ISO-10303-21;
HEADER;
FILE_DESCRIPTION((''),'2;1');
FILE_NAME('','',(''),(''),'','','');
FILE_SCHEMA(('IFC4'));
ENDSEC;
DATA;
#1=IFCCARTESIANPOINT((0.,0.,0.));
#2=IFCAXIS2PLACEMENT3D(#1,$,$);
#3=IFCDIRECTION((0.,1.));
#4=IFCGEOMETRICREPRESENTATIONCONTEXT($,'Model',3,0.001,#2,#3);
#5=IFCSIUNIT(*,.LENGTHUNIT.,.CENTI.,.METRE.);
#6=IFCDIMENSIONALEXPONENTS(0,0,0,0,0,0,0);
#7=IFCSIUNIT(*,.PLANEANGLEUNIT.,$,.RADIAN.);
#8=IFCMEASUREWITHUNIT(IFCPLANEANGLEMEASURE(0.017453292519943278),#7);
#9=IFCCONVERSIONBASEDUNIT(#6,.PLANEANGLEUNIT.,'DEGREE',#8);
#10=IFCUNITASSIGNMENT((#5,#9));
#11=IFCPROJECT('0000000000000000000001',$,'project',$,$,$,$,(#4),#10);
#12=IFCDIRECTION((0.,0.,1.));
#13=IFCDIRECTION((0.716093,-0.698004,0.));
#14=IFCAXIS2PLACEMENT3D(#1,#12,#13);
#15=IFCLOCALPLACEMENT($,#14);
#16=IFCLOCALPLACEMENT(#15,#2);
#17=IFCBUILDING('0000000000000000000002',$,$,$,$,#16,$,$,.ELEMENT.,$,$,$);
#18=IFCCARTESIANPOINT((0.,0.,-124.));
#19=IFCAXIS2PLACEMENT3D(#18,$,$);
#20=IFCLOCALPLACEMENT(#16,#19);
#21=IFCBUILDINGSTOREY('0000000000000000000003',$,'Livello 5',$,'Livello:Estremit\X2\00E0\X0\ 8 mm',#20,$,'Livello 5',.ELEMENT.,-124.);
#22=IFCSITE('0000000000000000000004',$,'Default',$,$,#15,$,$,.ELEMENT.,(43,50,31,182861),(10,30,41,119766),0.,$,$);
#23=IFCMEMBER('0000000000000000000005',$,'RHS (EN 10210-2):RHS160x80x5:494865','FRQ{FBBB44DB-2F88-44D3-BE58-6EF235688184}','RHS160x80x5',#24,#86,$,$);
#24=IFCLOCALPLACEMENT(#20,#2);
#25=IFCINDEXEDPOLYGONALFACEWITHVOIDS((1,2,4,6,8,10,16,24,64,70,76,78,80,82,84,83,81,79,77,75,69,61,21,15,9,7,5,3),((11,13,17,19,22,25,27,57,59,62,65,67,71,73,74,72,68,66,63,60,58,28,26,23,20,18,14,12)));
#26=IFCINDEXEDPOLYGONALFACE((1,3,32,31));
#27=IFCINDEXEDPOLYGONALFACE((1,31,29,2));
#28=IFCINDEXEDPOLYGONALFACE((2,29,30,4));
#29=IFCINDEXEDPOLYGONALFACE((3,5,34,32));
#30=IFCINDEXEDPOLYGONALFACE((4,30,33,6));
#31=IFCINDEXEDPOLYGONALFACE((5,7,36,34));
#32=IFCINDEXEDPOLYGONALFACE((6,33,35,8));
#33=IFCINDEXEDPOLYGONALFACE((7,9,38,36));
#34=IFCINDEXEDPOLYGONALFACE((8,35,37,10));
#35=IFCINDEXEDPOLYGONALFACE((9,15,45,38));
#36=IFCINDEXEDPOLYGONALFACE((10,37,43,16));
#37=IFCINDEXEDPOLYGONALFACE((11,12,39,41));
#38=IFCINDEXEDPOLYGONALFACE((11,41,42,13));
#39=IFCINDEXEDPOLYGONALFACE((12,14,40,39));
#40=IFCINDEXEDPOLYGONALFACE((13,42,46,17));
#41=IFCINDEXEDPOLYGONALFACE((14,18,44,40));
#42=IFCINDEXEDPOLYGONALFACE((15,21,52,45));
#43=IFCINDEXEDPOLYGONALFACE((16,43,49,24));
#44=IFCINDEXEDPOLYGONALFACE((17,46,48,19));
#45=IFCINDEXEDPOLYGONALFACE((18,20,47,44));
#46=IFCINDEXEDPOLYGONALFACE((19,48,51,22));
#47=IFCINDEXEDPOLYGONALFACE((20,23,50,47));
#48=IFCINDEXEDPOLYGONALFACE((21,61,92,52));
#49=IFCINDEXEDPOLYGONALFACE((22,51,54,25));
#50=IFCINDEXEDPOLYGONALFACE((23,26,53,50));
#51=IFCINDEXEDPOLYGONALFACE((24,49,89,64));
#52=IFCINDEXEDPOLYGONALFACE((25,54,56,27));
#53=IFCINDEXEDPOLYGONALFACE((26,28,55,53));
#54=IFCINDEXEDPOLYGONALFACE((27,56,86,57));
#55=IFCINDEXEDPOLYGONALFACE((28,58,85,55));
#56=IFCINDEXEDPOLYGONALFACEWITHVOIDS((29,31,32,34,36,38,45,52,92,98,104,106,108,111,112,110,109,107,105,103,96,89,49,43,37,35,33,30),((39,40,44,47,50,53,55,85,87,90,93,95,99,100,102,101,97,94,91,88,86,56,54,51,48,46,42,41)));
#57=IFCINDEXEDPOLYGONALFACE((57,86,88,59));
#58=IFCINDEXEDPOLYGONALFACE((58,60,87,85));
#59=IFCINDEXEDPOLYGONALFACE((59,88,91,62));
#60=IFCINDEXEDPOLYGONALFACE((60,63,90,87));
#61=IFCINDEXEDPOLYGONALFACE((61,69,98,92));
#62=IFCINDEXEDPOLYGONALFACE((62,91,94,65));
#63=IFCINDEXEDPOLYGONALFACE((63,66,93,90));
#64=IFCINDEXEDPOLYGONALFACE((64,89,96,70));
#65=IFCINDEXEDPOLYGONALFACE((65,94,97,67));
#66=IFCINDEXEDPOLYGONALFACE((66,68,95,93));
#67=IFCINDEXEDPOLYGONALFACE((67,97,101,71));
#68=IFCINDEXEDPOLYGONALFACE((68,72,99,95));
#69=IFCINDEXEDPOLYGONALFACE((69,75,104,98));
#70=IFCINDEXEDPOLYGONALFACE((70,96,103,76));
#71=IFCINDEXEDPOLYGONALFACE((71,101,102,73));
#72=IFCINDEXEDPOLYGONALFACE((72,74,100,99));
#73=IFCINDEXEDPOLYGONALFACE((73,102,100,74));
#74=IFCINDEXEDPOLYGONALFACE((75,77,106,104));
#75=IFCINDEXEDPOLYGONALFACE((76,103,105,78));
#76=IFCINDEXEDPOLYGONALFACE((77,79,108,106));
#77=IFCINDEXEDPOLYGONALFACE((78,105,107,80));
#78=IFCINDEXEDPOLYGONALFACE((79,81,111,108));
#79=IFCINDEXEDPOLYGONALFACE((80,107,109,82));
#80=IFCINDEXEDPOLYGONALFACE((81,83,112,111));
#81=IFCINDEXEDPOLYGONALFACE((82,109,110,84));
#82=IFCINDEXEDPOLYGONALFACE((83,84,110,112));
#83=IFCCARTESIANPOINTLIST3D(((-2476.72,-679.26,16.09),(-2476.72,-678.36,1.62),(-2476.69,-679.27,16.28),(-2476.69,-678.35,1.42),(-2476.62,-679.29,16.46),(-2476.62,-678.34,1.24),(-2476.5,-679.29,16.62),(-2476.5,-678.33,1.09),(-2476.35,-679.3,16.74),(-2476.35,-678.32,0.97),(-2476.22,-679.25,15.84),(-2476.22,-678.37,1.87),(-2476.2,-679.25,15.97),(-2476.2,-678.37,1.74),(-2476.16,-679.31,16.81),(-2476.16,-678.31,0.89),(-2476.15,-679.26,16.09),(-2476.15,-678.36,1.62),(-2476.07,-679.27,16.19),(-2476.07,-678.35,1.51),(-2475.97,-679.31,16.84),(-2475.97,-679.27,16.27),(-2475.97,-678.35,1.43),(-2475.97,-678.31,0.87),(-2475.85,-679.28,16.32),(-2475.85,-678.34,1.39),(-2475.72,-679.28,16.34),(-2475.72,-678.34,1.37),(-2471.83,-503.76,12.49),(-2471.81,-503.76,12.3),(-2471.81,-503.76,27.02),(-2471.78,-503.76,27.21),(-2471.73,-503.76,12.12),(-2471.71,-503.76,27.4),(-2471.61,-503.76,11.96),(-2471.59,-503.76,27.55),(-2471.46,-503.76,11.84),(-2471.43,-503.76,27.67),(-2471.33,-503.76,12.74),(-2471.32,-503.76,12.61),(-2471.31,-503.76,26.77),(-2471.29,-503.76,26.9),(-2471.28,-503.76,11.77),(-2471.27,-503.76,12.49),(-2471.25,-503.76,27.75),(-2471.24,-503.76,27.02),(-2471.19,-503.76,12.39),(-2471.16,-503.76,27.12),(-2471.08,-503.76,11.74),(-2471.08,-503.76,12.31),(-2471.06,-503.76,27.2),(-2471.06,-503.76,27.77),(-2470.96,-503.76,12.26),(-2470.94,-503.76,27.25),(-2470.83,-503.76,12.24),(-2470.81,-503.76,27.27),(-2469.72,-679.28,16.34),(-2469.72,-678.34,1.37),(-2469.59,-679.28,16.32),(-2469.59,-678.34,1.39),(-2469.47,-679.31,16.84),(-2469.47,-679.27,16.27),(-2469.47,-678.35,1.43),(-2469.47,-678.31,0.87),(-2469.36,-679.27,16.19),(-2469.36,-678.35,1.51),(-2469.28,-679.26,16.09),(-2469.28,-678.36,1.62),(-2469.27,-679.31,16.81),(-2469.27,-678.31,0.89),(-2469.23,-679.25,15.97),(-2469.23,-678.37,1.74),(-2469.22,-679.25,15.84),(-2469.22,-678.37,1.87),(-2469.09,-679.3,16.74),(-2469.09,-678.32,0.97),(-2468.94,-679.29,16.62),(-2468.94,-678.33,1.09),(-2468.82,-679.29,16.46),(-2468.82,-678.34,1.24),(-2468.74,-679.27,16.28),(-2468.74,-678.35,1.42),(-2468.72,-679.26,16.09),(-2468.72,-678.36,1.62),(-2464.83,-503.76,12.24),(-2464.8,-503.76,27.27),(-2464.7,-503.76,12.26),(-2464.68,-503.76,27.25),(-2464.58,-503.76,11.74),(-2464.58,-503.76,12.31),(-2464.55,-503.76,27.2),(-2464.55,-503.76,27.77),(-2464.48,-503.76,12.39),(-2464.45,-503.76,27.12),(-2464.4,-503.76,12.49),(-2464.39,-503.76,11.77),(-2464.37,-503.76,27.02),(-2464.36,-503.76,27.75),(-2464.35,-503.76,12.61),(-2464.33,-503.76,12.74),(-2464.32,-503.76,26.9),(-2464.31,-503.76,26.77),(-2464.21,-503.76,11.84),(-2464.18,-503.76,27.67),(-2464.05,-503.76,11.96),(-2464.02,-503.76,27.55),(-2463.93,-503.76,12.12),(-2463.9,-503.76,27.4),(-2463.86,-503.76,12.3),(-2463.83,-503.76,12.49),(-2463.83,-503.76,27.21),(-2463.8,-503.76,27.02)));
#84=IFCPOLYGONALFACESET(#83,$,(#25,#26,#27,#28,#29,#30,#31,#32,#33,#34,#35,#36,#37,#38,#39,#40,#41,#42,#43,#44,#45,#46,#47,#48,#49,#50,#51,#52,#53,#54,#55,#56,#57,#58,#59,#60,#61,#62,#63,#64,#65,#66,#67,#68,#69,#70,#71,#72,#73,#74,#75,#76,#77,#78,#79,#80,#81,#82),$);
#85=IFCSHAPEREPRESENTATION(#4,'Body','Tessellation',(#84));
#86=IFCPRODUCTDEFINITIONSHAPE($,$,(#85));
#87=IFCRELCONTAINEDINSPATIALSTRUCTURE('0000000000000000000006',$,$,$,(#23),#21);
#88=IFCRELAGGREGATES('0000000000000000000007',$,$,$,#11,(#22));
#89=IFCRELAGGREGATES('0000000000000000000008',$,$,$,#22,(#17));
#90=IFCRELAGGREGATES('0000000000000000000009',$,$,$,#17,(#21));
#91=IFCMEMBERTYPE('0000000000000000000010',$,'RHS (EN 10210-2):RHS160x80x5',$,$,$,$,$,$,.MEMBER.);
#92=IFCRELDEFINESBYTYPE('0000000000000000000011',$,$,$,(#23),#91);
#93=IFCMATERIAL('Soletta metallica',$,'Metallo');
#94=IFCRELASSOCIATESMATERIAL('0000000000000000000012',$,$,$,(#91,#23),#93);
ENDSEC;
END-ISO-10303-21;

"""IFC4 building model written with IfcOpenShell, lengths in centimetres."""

from ifc_helpers import new_model, entity, si_unit, converted_unit, direction, frame, origin, origin_2d, place, context, project, spatial, hollow_rectangle, extrude, clip, halfspace, material, type_object, element, save


model = new_model("IFC4")

# Units and contexts
model_context = context("Model", 3, precision=0.001, world=origin(), true_north=direction((0.0, 1.0)))
ifc_project = project(units=[si_unit("LENGTHUNIT", "METRE", prefix="CENTI"), converted_unit("PLANEANGLEUNIT", "DEGREE", entity("IfcPlaneAngleMeasure", 0.017453292519943278), si_unit("PLANEANGLEUNIT", "RADIAN"), dimensions=[0, 0, 0, 0, 0, 0, 0])], contexts=[model_context])

# Site, building, storey
site_placement = place(None, frame((0.0, 0.0, 0.0), z_axis=(0.0, 0.0, 1.0), x_axis=(0.716093, -0.698004, 0.0)))
site = spatial("IfcSite", under=ifc_project, at=site_placement, Name="Default", CompositionType="ELEMENT", RefLatitude=(43, 50, 31, 182861), RefLongitude=(10, 30, 41, 119766), RefElevation=0.0)
building_placement = place(site_placement, origin())
building = spatial("IfcBuilding", under=site, at=building_placement, CompositionType="ELEMENT")
storey_placement = place(building_placement, frame((0.0, 0.0, -124.0)))
storey = spatial("IfcBuildingStorey", under=building, at=storey_placement, Name="Livello 5", ObjectType="Livello:Estremità 8 mm", LongName="Livello 5", CompositionType="ELEMENT", Elevation=-124.0)

# Shared definitions
ifc_material_1 = material(Name="Soletta metallica", Category="Metallo")

# Member
member_type_1 = type_object("IfcMemberType", Name="RHS (EN 10210-2):RHS160x80x5", PredefinedType="MEMBER", material=ifc_material_1)
member_1_placement = place(storey_placement, frame((-2473.81, -717.68, 6.43), z_axis=(-0.027926, -0.997677, -0.062135), x_axis=(0.99961, -0.027872, -0.001736)))
element("IfcMember", 1, at=member_1_placement, inside=storey, type_object=member_type_1, material=ifc_material_1, Name="RHS (EN 10210-2):RHS160x80x5:494865", Description="FRQ{FBBB44DB-2F88-44D3-BE58-6EF235688184}", ObjectType="RHS160x80x5", context=model_context, shape_type="Clipping", body=[
    clip(clip(extrude(hollow_rectangle(XDim=8.0, YDim=16.0, WallThickness=0.5, InnerFilletRadius=0.5, OuterFilletRadius=0.75, at=origin_2d()), origin(), (0.0, 0.0, -1.0), 242.93), halfspace(frame((2466.85, 99.74, -289.82), z_axis=(0.02798, 0.062159, 0.997674), x_axis=(0.999608, -0.00174, -0.027926)), True)), halfspace(frame((2471.88, 68.35, -108.01), z_axis=(-0.027926, 0.000109, -0.99961), x_axis=(-0.999608, 0.00174, 0.027926)), True)),
])

save(model, "model.ifc")
